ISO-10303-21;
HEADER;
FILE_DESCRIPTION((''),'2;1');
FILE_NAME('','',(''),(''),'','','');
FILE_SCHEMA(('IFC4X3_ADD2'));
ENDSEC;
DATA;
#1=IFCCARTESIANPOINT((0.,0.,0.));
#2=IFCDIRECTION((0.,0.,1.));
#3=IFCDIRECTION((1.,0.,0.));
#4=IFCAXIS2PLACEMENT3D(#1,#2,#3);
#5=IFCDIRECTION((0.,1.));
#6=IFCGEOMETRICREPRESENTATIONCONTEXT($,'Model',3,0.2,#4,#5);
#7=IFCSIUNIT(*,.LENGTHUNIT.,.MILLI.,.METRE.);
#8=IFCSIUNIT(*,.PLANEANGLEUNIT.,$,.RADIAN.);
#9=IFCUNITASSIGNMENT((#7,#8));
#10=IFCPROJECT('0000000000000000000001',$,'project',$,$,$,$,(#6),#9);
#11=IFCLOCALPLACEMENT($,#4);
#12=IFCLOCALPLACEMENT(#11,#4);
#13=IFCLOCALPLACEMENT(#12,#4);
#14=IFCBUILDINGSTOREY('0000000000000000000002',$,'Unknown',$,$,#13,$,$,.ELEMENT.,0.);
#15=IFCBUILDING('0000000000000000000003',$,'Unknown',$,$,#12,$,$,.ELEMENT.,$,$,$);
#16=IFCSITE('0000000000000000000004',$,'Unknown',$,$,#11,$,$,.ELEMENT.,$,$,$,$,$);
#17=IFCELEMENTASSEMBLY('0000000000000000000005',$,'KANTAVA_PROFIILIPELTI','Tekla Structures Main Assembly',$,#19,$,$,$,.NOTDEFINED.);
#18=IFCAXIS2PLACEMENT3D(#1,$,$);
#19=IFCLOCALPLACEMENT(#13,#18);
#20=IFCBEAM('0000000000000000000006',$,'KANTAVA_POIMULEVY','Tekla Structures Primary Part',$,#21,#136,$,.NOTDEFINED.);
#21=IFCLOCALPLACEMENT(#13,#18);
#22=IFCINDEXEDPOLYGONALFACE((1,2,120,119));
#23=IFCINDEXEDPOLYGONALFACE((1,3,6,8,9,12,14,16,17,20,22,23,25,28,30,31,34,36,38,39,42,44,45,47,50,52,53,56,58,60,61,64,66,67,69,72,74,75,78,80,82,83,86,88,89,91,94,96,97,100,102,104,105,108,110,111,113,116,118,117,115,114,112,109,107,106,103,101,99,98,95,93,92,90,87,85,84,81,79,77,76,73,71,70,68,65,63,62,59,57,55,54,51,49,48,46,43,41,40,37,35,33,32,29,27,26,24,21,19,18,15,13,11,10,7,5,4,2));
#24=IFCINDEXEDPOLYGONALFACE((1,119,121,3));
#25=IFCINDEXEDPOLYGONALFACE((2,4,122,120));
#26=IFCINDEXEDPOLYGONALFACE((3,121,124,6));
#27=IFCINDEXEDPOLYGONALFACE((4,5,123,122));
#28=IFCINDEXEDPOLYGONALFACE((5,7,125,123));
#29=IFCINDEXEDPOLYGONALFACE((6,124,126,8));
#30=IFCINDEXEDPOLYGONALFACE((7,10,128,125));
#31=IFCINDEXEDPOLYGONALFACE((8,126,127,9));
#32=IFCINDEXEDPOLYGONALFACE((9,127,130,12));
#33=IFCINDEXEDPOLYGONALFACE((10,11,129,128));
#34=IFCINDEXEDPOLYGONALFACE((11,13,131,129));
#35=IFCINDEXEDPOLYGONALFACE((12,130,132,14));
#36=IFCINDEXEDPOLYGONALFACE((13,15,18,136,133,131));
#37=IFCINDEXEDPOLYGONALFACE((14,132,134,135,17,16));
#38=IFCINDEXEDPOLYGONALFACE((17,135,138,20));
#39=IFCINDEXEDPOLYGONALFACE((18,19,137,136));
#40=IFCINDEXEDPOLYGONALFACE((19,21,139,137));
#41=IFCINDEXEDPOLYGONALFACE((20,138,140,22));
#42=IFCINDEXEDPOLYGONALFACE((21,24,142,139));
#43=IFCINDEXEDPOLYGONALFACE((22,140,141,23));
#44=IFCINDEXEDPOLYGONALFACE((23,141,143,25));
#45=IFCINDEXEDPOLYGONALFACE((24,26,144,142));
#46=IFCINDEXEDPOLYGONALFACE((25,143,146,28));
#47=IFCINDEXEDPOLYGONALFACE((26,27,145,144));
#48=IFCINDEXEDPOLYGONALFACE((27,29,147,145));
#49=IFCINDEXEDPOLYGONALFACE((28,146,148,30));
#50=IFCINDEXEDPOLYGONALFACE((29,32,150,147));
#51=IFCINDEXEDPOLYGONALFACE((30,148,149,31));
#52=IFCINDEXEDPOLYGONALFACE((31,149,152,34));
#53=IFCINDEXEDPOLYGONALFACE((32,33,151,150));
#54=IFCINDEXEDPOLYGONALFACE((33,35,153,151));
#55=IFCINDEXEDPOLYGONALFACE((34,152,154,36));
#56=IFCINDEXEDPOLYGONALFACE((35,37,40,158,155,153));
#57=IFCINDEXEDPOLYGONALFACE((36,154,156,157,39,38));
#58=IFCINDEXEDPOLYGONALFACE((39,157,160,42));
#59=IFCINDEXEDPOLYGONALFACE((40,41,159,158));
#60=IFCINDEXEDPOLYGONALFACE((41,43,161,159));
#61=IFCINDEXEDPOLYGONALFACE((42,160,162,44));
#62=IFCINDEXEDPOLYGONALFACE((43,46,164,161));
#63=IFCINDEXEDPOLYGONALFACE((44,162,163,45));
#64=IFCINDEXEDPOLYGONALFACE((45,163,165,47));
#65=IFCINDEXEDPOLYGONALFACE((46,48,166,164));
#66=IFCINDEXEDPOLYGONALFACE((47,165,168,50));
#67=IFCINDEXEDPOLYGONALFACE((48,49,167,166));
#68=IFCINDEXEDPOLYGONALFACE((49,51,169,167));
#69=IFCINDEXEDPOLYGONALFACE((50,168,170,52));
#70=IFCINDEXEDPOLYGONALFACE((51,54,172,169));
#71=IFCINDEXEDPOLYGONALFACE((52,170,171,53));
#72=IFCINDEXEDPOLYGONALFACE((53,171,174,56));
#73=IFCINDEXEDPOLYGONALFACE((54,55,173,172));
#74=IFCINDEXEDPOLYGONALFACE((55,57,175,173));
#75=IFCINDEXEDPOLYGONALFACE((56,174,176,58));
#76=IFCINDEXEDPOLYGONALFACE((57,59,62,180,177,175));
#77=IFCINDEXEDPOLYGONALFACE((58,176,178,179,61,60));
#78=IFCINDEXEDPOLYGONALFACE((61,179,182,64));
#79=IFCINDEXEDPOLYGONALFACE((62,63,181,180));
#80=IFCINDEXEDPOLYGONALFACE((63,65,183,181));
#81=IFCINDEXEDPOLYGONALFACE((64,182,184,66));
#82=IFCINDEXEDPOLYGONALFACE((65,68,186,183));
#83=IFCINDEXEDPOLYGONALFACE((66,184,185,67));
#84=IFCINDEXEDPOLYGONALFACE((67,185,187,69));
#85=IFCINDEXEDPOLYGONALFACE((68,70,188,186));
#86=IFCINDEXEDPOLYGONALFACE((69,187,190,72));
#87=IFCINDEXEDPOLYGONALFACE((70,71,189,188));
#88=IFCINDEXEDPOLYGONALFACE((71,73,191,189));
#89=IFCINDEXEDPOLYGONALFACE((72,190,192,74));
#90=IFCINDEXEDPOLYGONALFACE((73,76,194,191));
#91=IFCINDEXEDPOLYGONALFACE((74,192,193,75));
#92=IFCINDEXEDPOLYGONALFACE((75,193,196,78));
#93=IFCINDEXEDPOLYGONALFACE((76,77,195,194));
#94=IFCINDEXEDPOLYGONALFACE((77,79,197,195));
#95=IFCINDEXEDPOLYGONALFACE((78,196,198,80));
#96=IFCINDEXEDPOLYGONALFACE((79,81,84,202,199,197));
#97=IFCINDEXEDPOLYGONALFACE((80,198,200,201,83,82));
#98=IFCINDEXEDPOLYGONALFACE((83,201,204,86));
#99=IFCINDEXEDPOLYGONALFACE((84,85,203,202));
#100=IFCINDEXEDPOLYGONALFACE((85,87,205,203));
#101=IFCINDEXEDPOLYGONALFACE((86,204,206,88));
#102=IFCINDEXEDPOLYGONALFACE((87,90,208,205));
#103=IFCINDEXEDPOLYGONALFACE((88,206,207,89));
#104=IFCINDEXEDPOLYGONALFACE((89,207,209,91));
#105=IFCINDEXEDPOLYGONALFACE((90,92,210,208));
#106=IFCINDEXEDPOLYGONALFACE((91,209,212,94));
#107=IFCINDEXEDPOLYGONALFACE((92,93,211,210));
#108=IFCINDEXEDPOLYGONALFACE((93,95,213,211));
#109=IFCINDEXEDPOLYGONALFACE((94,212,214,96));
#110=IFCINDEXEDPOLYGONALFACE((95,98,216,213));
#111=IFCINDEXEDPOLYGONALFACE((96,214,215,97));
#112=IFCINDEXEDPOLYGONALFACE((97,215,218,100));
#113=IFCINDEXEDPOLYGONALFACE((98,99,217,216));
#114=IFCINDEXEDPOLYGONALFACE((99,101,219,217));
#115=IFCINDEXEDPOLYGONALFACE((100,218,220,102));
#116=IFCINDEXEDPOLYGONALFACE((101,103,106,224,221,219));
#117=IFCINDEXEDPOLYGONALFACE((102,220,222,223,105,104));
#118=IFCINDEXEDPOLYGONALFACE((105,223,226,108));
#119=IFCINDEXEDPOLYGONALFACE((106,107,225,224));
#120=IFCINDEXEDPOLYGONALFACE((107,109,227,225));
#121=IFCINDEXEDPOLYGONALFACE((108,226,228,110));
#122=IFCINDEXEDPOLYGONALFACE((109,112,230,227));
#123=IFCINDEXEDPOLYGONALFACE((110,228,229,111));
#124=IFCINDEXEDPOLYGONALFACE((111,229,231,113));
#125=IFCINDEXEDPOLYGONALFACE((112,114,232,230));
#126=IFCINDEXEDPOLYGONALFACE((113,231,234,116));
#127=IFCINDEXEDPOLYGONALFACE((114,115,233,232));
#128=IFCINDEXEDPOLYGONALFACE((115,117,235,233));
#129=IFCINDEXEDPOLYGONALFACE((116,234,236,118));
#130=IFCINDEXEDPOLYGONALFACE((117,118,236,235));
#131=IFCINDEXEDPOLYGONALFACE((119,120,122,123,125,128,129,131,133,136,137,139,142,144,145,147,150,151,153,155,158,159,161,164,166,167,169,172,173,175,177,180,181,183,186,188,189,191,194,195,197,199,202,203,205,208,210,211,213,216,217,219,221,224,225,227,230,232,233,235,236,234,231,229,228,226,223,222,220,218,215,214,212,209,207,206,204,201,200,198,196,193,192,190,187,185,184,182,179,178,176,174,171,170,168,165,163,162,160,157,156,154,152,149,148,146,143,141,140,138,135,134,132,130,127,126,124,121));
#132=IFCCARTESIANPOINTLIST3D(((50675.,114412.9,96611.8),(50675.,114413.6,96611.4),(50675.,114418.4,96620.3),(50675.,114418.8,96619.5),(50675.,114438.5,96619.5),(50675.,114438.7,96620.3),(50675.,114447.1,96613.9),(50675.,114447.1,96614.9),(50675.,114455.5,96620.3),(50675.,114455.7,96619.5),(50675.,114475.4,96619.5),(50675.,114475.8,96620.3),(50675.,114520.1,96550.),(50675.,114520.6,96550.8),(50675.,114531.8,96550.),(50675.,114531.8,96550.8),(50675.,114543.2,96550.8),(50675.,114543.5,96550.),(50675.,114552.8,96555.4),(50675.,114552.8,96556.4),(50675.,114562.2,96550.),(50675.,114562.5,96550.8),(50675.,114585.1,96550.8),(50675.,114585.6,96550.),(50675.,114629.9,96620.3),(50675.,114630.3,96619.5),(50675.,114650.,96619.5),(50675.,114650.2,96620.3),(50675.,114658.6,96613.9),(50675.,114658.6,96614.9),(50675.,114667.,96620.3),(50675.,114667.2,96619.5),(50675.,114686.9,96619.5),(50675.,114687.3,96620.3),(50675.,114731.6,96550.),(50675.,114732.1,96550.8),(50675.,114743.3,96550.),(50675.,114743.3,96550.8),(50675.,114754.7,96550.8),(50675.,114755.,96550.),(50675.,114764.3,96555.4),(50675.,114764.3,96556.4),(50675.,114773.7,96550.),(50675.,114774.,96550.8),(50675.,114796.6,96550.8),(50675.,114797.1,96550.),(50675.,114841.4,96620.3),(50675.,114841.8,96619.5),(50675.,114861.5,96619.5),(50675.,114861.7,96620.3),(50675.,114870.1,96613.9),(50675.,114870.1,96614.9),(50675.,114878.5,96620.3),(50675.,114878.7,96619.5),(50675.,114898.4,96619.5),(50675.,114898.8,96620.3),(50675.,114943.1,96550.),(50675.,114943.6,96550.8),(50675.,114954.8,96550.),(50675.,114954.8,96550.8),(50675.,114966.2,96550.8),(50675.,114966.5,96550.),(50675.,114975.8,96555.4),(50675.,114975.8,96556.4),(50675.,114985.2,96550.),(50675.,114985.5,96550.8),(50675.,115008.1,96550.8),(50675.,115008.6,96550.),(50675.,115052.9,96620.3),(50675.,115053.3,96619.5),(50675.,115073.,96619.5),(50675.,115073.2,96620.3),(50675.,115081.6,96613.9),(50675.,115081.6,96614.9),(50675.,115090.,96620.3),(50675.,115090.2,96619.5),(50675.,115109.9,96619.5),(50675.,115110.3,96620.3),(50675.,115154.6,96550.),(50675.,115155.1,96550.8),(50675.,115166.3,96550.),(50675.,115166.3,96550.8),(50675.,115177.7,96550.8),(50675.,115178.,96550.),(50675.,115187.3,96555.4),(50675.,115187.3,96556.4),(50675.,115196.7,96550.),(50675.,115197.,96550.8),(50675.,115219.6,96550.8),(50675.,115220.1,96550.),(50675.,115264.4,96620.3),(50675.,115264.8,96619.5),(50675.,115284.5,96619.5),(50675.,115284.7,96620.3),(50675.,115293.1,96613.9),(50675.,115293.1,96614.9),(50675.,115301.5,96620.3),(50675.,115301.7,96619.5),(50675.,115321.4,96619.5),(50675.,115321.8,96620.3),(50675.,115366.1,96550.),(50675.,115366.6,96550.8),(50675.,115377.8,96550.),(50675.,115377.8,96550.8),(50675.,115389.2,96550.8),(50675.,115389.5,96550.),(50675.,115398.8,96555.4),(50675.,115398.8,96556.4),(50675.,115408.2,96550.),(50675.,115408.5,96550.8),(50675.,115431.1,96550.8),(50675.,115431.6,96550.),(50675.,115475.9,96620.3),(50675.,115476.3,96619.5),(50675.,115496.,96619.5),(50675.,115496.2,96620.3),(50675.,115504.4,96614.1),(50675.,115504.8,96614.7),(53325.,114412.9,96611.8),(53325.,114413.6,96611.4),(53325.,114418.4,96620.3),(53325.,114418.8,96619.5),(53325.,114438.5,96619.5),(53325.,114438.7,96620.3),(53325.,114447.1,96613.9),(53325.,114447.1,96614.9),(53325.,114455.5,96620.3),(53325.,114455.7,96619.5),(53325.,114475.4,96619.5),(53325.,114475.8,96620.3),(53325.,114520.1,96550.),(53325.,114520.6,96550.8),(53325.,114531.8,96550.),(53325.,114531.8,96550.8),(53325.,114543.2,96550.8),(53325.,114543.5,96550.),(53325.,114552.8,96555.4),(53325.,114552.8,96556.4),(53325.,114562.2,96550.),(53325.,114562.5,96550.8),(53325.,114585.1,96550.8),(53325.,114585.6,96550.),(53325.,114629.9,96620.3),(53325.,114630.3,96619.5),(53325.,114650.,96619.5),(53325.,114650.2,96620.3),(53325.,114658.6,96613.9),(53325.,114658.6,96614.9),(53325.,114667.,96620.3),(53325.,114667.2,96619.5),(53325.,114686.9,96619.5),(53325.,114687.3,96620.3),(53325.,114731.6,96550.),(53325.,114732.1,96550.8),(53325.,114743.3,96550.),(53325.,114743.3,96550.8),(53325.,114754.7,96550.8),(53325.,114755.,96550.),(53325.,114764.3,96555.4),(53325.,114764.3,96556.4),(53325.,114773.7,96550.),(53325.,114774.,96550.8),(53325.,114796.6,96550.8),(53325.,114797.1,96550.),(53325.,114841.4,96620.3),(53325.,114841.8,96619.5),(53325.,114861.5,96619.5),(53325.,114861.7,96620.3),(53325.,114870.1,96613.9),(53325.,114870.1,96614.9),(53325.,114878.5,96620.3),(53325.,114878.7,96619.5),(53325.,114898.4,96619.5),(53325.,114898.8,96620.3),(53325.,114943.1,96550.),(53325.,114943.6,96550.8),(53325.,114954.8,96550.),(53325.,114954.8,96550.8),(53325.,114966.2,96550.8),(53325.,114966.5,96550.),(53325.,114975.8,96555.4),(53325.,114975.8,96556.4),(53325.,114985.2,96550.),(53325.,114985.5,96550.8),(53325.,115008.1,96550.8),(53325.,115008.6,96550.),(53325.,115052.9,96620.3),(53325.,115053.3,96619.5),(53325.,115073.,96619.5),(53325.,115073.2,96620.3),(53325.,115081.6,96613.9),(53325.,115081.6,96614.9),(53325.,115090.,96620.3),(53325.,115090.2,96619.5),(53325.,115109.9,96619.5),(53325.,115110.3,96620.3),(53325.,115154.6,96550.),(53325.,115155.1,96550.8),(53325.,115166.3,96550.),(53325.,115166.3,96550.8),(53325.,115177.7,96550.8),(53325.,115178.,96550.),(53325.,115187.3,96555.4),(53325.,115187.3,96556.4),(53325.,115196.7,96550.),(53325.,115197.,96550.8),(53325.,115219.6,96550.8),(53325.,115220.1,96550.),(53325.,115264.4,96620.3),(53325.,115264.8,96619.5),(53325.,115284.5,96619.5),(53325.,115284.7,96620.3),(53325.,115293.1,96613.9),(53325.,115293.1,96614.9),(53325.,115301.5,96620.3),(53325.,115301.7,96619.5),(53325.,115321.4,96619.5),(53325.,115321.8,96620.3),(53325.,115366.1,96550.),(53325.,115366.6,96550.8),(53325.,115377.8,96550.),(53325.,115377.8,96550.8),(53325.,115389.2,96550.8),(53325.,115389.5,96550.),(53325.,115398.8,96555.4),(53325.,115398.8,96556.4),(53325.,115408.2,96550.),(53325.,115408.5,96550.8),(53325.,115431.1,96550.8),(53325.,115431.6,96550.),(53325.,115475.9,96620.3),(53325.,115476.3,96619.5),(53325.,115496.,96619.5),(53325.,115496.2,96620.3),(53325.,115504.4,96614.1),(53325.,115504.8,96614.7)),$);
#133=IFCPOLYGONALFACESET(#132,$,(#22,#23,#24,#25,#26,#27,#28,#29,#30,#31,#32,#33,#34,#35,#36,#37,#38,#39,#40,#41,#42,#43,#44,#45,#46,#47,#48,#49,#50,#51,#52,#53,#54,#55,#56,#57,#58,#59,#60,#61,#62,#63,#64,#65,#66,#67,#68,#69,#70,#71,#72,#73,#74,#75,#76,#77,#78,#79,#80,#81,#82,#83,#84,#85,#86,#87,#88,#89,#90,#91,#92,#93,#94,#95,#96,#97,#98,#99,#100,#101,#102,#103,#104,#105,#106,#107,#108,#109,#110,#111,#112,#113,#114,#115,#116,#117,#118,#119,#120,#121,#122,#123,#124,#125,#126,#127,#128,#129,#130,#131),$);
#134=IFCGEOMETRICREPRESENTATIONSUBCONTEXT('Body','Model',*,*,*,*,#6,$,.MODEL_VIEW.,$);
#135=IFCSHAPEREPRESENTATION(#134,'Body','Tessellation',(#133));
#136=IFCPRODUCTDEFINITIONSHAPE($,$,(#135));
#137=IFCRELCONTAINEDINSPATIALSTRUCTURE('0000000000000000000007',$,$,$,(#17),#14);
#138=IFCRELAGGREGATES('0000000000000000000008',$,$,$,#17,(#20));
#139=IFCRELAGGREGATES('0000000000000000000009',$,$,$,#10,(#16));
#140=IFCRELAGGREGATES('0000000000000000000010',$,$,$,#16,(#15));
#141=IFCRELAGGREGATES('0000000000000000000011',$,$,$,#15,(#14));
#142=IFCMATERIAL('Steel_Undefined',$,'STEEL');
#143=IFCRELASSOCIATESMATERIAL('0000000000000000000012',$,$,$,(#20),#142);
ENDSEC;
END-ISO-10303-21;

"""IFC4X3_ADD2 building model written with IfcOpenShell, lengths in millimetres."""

from ifc_helpers import new_model, si_unit, direction, frame, origin_with_axes, place, context, subcontext, project, spatial, line, indexed_curve, outline, extrude, material, element, aggregate, save


model = new_model("IFC4X3_ADD2")

# Units and contexts
model_context = context("Model", 3, precision=0.2, world=origin_with_axes(), true_north=direction((0.0, 1.0)))
body_context = subcontext(model_context, "Body", "Model", "MODEL_VIEW")
ifc_project = project(units=[si_unit("LENGTHUNIT", "METRE", prefix="MILLI"), si_unit("PLANEANGLEUNIT", "RADIAN")], contexts=[model_context])

# Site, building, storey
site_placement = place(None, origin_with_axes())
site = spatial("IfcSite", under=ifc_project, at=site_placement, Name="Unknown", CompositionType="ELEMENT")
building_placement = place(site_placement, origin_with_axes())
building = spatial("IfcBuilding", under=site, at=building_placement, Name="Unknown", CompositionType="ELEMENT")
storey_placement = place(building_placement, origin_with_axes())
storey = spatial("IfcBuildingStorey", under=building, at=storey_placement, Name="Unknown", CompositionType="ELEMENT", Elevation=0.0)

# Element assembly, beam
ifc_material_1 = material(Name="Steel_Undefined", Category="STEEL")
assembly_1_placement = place(storey_placement, frame((53325.0, 114975.8, 96585.2), z_axis=(0.0, 1.0, 0.0), x_axis=(-1.0, 0.0, 0.0)))
assembly_1 = element("IfcElementAssembly", 1, at=assembly_1_placement, inside=storey, Name="KANTAVA_PROFIILIPELTI", Description="Tekla Structures Main Assembly", PredefinedType="NOTDEFINED")
beam_1_placement = place(assembly_1_placement, origin_with_axes())
beam_1 = element("IfcBeam", 2, at=beam_1_placement, material=ifc_material_1, Name="KANTAVA_POIMULEVY", Description="Tekla Structures Primary Part", PredefinedType="NOTDEFINED", context=body_context, shape_type="SolidModel", body=[
    extrude(outline(indexed_curve([(529.0, 29.6), (520.4, 35.1), (500.0, 35.1), (455.3, -34.4), (432.6, -34.4), (423.0, -28.8), (413.4, -34.4), (402.0, -34.4), (390.7, -34.4), (346.0, 35.1), (325.6, 35.1), (317.2, 29.7), (308.9, 35.1), (288.5, 35.1), (243.8, -34.4), (221.1, -34.4), (211.5, -28.8), (201.9, -34.4), (190.5, -34.4), (179.2, -34.4), (134.5, 35.1), (114.1, 35.1), (105.8, 29.7), (97.4, 35.1), (77.0, 35.1), (32.3, -34.4), (9.6, -34.4), (0.0, -28.8), (-9.6, -34.4), (-21.0, -34.4), (-32.3, -34.4), (-77.0, 35.1), (-97.4, 35.1), (-105.8, 29.7), (-114.1, 35.1), (-134.5, 35.1), (-179.2, -34.4), (-201.9, -34.4), (-211.5, -28.8), (-221.1, -34.4), (-232.5, -34.4), (-243.8, -34.4), (-288.5, 35.1), (-308.9, 35.1), (-317.2, 29.7), (-325.6, 35.1), (-346.0, 35.1), (-390.7, -34.4), (-413.4, -34.4), (-423.0, -28.8), (-432.6, -34.4), (-444.0, -34.4), (-455.3, -34.4), (-500.0, 35.1), (-520.4, 35.1), (-528.8, 29.7), (-537.1, 35.1), (-557.5, 35.1), (-562.9, 26.7), (-562.2, 26.2), (-557.0, 34.4), (-537.4, 34.4), (-528.8, 28.8), (-520.1, 34.4), (-500.5, 34.4), (-455.7, -35.1), (-444.0, -35.1), (-432.4, -35.1), (-423.0, -29.7), (-413.6, -35.1), (-390.3, -35.1), (-345.5, 34.4), (-325.9, 34.4), (-317.2, 28.8), (-308.6, 34.4), (-289.0, 34.4), (-244.2, -35.1), (-232.5, -35.1), (-220.9, -35.1), (-211.5, -29.7), (-202.1, -35.1), (-178.8, -35.1), (-134.0, 34.4), (-114.4, 34.4), (-105.8, 28.8), (-97.1, 34.4), (-77.5, 34.4), (-32.7, -35.1), (-21.0, -35.1), (-9.4, -35.1), (0.0, -29.7), (9.4, -35.1), (32.7, -35.1), (77.5, 34.4), (97.1, 34.4), (105.8, 28.8), (114.4, 34.4), (134.0, 34.4), (178.8, -35.1), (190.5, -35.1), (202.1, -35.1), (211.5, -29.7), (220.9, -35.1), (244.2, -35.1), (289.0, 34.4), (308.6, 34.4), (317.2, 28.8), (325.9, 34.4), (345.5, 34.4), (390.3, -35.1), (402.0, -35.1), (413.6, -35.1), (423.0, -29.7), (432.4, -35.1), (455.7, -35.1), (500.5, 34.4), (520.1, 34.4), (528.5, 28.9)], segments=[line(1, 2, 3, 4, 5, 6, 7, 8, 9, 10, 11, 12, 13, 14, 15, 16, 17, 18, 19, 20, 21, 22, 23, 24, 25, 26, 27, 28, 29, 30, 31, 32, 33, 34, 35, 36, 37, 38, 39, 40, 41, 42, 43, 44, 45, 46, 47, 48, 49, 50, 51, 52, 53, 54, 55, 56, 57, 58, 59, 60, 61, 62, 63, 64, 65, 66, 67, 68, 69, 70, 71, 72, 73, 74, 75, 76, 77, 78, 79, 80, 81, 82, 83, 84, 85, 86, 87, 88, 89, 90, 91, 92, 93, 94, 95, 96, 97, 98, 99, 100, 101, 102, 103, 104, 105, 106, 107, 108, 109, 110, 111, 112, 113, 114, 115, 116, 117, 118, 1)])), frame((0.0, 0.0, 0.0), z_axis=(-1.0, 0.0, 0.0), x_axis=(0.0, 0.0, 1.0)), (0.0, 0.0, -1.0), 2650.0),
])
aggregate(assembly_1, [beam_1])

save(model, "model.ifc")
